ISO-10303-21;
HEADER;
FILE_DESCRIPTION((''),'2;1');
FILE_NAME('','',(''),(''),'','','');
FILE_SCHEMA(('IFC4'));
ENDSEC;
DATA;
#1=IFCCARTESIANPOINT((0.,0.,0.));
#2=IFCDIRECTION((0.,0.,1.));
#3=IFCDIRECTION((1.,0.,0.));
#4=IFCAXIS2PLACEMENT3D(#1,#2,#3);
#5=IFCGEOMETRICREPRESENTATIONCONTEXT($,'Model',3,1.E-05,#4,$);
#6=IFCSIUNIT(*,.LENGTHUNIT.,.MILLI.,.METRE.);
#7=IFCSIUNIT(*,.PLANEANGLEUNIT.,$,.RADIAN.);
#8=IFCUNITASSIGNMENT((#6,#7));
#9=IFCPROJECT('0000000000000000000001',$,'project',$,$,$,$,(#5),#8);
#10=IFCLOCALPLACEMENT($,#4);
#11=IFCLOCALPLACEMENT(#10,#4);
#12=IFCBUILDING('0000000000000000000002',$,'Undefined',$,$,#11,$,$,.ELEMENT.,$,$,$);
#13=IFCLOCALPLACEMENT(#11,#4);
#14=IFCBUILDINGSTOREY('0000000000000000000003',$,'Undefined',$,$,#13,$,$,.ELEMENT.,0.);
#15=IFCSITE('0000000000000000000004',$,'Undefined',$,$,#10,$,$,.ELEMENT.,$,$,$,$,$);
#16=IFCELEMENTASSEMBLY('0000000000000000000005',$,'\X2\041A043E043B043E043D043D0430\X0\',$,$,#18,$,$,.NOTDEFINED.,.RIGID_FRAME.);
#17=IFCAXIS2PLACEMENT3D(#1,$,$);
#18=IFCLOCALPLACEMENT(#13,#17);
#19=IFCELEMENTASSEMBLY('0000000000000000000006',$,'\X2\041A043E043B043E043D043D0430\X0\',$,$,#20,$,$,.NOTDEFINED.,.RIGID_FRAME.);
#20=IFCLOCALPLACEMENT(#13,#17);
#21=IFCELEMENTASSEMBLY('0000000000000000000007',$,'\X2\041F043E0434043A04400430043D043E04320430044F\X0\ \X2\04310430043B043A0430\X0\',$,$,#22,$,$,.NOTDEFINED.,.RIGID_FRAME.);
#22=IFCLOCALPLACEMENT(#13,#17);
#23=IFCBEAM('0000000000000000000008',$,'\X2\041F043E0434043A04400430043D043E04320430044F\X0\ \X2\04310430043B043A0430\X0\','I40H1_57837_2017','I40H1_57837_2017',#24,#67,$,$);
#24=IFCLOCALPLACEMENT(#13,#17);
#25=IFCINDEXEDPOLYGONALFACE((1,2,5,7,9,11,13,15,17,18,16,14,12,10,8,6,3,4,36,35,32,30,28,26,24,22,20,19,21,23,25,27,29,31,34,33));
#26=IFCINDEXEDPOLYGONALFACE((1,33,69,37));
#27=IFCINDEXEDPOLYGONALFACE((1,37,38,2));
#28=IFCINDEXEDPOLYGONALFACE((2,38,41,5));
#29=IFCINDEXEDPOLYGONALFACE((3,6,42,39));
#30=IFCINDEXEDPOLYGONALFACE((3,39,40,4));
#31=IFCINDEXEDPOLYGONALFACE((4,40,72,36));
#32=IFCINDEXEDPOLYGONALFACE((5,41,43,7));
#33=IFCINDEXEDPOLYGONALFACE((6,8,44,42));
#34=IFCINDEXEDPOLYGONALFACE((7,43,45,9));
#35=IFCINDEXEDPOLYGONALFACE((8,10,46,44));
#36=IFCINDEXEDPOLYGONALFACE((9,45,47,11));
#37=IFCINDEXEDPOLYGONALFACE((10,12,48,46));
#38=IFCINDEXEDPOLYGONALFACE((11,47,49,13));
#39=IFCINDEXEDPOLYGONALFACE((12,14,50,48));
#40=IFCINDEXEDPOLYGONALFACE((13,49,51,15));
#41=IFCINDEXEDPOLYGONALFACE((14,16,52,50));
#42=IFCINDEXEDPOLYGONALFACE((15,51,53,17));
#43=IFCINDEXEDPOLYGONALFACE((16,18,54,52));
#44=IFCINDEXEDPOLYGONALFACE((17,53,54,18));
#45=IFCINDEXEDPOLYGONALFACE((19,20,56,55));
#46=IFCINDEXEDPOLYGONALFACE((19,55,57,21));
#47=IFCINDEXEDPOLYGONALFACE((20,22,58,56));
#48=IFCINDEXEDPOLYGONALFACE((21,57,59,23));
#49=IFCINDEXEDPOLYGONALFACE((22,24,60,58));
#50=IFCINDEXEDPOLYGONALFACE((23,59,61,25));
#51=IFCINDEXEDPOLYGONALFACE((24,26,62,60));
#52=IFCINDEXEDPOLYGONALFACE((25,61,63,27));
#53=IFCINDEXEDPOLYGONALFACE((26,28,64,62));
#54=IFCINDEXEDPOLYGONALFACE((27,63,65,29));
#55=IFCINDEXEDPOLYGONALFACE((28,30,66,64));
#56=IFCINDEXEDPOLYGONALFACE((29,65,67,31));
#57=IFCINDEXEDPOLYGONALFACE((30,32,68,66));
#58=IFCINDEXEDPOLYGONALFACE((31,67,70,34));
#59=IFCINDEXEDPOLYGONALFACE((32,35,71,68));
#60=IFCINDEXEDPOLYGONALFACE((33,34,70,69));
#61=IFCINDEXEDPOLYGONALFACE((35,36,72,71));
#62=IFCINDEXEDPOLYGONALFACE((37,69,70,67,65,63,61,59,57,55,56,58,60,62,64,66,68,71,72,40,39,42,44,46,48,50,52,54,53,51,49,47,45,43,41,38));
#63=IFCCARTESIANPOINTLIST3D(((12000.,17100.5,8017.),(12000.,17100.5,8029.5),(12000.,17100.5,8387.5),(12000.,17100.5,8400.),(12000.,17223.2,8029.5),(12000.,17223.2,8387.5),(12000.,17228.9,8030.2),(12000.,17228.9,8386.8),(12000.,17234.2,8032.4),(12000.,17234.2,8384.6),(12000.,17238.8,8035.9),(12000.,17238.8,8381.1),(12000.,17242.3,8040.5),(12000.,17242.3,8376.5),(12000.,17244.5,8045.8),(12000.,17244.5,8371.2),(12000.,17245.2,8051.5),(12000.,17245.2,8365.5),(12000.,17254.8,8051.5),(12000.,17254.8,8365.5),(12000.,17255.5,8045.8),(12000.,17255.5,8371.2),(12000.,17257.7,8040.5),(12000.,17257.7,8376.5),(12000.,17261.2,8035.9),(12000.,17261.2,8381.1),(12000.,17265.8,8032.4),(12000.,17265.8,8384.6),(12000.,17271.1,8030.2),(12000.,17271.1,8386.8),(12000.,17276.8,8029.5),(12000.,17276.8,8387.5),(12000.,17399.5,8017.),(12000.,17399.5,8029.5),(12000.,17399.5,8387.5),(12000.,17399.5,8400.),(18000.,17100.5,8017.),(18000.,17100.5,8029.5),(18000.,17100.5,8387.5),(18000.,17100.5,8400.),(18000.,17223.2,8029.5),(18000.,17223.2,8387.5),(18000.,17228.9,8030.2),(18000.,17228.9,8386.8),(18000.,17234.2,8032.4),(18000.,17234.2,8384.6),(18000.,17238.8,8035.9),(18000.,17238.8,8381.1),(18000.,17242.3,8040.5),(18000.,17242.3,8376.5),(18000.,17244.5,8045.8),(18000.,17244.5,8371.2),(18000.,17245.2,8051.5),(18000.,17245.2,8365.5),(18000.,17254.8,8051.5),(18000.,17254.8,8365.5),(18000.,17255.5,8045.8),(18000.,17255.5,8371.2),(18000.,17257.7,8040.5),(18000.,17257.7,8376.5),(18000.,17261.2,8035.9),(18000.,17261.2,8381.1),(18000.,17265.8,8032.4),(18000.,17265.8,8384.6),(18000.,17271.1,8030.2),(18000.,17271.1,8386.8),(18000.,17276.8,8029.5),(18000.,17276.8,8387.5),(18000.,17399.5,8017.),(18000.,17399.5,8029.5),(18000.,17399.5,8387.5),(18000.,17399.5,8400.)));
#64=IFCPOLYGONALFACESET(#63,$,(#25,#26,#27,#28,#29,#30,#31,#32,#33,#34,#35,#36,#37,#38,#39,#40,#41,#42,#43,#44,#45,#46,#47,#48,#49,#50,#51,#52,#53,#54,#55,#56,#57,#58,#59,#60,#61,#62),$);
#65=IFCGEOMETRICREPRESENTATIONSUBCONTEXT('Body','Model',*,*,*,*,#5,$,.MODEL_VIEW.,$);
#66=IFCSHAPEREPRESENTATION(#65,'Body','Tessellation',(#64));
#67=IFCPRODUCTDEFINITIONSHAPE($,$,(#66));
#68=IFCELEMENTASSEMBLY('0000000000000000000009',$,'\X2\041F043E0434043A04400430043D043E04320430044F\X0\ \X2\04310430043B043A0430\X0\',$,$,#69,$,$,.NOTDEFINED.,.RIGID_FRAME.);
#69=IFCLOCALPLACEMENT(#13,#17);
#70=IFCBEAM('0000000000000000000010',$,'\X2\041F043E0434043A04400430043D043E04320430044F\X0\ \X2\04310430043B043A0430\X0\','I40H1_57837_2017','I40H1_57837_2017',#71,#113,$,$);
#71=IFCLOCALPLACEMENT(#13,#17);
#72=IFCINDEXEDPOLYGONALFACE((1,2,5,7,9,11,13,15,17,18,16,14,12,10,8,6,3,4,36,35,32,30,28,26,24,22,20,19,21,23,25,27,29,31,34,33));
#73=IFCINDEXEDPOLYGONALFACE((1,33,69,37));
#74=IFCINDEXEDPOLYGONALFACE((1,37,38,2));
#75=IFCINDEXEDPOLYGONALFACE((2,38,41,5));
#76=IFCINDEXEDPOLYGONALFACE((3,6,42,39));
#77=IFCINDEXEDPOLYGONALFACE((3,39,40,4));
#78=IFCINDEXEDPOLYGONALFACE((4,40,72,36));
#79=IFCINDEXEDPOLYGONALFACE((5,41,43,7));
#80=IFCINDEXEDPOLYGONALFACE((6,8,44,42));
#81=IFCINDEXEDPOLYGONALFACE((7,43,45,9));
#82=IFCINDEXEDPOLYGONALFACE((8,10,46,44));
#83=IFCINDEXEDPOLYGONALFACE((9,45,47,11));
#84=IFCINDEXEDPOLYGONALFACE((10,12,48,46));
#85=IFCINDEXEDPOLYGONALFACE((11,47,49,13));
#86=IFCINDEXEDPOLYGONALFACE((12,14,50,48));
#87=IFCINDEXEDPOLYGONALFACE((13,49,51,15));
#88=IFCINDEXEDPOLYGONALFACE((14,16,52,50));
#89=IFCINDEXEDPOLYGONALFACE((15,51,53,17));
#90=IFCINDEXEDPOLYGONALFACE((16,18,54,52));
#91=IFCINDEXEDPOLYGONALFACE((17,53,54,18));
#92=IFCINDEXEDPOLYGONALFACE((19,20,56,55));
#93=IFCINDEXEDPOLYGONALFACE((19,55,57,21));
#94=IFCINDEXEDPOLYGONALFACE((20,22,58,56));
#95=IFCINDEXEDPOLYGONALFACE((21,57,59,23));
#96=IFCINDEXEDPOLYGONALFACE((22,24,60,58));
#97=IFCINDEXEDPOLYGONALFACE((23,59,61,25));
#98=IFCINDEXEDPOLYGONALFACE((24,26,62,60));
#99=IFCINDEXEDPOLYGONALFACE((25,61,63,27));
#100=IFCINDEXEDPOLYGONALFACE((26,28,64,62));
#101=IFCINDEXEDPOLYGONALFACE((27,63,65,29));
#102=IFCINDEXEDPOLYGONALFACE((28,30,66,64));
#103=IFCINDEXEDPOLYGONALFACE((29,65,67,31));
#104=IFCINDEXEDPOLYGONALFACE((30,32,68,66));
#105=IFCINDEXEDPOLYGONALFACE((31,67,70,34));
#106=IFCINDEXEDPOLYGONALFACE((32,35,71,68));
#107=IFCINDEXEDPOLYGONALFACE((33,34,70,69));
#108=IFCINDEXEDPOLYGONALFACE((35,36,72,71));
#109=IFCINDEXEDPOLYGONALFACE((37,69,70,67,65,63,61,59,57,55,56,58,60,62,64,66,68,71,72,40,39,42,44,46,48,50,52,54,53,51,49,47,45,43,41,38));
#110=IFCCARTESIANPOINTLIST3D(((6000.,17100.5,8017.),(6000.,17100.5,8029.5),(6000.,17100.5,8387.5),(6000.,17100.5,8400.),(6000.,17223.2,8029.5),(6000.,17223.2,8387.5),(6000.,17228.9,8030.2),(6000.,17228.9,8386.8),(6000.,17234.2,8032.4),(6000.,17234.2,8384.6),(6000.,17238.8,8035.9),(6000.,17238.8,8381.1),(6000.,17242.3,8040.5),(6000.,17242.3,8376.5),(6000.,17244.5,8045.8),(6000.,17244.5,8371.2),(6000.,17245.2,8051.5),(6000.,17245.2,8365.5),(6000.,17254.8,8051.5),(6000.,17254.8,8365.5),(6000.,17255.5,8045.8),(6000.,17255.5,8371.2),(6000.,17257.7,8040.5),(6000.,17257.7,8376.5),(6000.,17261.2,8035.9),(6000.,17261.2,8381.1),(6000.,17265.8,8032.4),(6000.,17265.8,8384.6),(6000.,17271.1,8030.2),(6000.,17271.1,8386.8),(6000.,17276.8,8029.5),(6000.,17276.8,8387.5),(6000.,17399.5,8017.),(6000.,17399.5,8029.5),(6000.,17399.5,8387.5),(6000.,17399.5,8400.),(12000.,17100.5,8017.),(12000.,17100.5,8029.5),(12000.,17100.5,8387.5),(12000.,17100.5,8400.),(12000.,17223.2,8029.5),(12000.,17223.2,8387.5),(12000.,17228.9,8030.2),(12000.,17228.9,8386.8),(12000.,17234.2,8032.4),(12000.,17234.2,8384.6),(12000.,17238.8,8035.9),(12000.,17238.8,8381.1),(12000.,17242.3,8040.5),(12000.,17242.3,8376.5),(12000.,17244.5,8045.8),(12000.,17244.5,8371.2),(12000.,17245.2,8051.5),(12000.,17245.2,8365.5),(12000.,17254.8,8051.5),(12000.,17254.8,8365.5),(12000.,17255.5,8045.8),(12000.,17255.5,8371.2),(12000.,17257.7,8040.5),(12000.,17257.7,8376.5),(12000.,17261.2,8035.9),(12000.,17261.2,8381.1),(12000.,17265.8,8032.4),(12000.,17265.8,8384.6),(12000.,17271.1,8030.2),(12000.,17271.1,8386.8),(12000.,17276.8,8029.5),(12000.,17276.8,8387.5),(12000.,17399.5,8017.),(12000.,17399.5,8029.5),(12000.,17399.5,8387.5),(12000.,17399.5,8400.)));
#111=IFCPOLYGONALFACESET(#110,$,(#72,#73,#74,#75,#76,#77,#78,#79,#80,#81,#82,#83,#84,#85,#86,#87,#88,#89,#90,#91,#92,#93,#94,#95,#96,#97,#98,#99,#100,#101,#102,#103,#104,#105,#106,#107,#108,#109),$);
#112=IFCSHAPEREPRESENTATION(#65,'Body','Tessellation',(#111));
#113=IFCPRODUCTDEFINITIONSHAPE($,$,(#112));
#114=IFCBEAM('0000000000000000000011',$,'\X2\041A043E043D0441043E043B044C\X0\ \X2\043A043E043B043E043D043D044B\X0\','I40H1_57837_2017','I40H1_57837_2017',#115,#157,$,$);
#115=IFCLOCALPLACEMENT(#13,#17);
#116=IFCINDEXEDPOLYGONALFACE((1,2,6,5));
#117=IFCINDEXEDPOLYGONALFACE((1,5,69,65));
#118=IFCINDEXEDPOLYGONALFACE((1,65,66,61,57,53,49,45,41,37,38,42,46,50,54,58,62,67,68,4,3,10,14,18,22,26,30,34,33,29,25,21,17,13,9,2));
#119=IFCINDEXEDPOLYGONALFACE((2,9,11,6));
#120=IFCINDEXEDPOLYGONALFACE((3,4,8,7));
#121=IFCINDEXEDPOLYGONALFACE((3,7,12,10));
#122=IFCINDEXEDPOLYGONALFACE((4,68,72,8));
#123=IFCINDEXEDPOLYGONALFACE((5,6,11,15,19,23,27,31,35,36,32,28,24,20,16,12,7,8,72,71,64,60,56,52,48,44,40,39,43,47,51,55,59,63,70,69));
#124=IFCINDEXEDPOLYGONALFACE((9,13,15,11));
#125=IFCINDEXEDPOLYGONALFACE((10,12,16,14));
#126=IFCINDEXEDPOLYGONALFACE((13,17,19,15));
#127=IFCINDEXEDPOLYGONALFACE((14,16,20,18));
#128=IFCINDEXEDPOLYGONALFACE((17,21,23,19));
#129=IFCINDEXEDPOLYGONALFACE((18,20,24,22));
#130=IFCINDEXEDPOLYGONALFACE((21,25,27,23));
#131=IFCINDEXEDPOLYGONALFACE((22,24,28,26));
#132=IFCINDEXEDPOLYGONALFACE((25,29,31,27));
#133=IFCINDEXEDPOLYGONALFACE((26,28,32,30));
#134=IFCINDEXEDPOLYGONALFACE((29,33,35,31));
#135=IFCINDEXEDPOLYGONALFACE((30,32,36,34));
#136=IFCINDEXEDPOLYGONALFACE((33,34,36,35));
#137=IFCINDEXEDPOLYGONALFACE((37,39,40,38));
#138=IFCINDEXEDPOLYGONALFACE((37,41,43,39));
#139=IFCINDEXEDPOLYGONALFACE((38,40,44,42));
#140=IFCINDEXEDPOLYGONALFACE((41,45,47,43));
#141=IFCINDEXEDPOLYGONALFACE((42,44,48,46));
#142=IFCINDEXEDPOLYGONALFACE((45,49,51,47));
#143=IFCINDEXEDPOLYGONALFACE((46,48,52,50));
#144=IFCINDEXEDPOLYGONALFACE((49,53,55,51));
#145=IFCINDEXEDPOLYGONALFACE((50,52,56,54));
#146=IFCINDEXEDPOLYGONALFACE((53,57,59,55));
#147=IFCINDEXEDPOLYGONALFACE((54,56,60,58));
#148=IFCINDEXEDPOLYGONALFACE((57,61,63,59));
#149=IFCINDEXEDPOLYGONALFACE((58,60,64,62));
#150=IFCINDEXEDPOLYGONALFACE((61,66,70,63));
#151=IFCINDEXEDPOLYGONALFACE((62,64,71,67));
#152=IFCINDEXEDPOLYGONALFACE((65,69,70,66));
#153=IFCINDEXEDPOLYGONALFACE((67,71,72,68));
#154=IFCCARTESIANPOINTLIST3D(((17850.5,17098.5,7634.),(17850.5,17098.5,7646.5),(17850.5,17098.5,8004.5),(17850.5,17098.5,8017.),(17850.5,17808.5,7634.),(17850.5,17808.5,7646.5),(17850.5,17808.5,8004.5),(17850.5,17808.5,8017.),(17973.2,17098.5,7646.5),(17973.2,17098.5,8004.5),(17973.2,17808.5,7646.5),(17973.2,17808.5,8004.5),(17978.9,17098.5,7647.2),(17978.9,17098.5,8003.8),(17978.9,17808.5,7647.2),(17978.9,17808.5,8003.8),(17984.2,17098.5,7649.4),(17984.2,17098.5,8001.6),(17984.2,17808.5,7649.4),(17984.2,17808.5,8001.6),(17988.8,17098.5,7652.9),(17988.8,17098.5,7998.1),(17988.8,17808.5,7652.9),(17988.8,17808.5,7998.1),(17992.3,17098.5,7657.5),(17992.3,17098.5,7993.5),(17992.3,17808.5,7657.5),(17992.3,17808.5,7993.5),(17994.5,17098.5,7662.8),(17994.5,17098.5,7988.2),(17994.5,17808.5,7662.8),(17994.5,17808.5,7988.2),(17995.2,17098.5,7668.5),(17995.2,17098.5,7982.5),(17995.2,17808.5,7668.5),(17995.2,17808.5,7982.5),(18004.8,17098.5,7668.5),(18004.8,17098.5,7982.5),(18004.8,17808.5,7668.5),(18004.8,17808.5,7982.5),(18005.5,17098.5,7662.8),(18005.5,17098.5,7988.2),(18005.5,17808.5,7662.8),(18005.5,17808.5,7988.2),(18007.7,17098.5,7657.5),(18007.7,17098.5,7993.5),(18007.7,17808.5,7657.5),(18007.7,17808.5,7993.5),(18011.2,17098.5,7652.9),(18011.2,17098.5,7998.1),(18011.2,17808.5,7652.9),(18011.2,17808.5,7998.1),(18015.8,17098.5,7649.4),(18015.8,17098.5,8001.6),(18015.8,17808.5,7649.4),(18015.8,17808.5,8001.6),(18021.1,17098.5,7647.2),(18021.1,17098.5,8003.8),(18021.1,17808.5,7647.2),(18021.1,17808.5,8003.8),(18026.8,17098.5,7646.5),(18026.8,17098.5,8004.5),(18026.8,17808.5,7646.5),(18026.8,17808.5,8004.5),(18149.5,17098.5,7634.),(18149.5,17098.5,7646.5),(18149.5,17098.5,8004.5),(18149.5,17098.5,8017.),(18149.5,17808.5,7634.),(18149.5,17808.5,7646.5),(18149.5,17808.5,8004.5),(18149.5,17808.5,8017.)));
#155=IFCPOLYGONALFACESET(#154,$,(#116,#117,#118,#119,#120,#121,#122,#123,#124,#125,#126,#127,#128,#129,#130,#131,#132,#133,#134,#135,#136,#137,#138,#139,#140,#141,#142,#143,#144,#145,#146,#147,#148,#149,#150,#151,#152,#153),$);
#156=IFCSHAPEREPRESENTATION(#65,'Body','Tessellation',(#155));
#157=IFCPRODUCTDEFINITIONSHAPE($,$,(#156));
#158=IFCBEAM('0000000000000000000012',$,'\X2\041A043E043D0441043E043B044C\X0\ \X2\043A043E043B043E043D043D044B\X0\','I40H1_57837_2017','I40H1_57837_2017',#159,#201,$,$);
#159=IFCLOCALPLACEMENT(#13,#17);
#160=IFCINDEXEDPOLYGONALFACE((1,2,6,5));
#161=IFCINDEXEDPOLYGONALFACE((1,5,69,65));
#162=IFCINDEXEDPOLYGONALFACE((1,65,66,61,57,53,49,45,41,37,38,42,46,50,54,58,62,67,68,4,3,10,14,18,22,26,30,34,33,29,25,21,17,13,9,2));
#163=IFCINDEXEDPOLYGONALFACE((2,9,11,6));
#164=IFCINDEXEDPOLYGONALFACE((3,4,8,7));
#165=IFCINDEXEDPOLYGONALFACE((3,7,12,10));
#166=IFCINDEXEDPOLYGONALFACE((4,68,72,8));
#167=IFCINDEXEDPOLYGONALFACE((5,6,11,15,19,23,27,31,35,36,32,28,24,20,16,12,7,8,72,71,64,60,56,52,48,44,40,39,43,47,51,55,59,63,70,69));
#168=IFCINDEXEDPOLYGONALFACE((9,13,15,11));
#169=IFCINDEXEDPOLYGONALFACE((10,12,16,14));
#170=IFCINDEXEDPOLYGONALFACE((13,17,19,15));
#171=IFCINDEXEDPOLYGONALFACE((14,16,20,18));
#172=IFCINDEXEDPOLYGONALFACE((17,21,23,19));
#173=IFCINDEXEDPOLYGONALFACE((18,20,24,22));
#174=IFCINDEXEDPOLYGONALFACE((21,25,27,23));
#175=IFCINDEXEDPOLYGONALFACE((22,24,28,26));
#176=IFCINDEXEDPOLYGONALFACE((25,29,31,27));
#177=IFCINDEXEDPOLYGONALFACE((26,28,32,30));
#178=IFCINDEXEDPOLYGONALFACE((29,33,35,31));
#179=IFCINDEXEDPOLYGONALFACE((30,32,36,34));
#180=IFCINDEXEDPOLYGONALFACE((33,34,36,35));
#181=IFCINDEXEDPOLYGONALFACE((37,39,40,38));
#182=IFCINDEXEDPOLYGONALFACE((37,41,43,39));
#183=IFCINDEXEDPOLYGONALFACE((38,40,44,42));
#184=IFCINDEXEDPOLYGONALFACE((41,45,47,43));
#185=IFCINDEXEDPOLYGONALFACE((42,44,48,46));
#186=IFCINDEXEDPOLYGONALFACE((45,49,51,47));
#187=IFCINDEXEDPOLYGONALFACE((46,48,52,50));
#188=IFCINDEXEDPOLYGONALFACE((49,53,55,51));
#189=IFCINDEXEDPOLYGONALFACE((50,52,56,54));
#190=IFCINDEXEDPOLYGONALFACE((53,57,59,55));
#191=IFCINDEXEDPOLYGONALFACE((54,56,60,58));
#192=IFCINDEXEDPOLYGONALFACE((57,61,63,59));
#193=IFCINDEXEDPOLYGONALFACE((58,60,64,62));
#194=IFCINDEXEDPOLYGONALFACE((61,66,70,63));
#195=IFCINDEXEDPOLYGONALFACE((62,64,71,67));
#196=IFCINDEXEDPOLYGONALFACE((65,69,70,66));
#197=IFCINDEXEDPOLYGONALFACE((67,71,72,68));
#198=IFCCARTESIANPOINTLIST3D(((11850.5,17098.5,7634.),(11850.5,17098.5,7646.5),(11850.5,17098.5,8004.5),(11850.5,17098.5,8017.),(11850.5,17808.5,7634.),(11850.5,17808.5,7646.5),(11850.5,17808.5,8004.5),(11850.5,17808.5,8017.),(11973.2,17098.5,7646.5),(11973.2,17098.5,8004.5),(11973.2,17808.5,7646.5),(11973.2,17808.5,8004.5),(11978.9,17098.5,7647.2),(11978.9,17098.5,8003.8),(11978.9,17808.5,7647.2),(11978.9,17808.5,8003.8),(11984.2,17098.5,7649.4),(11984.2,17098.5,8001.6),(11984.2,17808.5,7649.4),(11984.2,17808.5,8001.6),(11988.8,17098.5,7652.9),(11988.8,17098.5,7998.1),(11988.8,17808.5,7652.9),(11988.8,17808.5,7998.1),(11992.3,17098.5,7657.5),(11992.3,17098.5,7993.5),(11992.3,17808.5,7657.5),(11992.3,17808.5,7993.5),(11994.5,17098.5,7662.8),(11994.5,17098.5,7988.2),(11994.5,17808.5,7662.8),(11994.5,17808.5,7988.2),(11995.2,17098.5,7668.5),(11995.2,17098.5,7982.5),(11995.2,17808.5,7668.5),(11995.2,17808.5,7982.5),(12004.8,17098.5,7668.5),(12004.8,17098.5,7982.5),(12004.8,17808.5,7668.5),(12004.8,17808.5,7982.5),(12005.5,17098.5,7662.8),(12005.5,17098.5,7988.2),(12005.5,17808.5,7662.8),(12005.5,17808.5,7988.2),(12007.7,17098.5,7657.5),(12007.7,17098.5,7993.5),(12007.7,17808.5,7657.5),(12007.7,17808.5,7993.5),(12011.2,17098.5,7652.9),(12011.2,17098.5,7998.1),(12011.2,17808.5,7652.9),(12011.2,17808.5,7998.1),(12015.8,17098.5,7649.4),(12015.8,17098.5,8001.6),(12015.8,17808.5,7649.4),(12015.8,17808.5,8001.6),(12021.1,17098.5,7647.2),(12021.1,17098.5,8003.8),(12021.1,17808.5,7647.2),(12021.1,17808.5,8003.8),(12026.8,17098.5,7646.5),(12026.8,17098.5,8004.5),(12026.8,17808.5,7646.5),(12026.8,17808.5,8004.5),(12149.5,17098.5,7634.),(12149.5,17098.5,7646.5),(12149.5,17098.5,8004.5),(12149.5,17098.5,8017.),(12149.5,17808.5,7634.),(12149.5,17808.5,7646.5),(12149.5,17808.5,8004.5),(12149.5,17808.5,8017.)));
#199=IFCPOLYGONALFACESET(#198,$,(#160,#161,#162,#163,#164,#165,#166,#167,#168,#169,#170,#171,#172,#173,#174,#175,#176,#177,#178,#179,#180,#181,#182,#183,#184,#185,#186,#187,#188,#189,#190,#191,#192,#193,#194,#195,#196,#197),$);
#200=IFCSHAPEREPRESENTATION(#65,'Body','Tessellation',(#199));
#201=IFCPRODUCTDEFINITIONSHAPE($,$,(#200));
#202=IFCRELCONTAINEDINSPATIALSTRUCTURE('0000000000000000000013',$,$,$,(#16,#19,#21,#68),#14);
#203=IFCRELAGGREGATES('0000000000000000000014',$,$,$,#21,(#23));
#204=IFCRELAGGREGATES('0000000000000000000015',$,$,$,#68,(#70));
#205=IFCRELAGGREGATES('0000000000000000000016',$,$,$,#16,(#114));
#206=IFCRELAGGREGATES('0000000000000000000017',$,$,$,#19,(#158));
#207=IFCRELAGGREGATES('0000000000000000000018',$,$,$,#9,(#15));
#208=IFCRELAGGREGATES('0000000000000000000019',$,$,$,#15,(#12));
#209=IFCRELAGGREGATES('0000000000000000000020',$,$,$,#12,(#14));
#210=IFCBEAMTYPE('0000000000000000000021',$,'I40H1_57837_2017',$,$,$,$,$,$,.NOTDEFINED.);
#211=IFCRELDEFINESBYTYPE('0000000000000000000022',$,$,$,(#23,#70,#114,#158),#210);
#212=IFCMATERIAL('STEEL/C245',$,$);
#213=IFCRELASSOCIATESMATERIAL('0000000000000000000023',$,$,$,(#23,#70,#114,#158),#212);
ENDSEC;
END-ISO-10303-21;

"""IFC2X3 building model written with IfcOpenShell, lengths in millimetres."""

from ifc_helpers import new_model, si_unit, frame, origin_with_axes, origin_2d_with_axis, place, context, subcontext, project, spatial, i_section, extrude, material, type_object, element, aggregate, save


model = new_model("IFC2X3")

# Units and contexts
model_context = context("Model", 3, precision=1e-05, world=origin_with_axes())
body_context = subcontext(model_context, "Body", "Model", "MODEL_VIEW")
ifc_project = project(units=[si_unit("LENGTHUNIT", "METRE", prefix="MILLI"), si_unit("PLANEANGLEUNIT", "RADIAN")], contexts=[model_context])

# Site, building, storey
site_placement = place(None, origin_with_axes())
site = spatial("IfcSite", under=ifc_project, at=site_placement, Name="Undefined", CompositionType="ELEMENT")
building_placement = place(site_placement, origin_with_axes())
building = spatial("IfcBuilding", under=site, at=building_placement, Name="Undefined", CompositionType="ELEMENT")
storey_placement = place(building_placement, origin_with_axes())
storey = spatial("IfcBuildingStorey", under=building, at=storey_placement, Name="Undefined", CompositionType="ELEMENT", Elevation=0.0)

# Element assemblies
assembly_1_placement = place(storey_placement, origin_with_axes())
assembly_1 = element("IfcElementAssembly", 1, at=assembly_1_placement, inside=storey, Name="Колонна", AssemblyPlace="NOTDEFINED", PredefinedType="RIGID_FRAME")
ifc_material_1 = material(Name="STEEL/C245")
assembly_2_placement = place(storey_placement, origin_with_axes())
assembly_2 = element("IfcElementAssembly", 2, at=assembly_2_placement, inside=storey, Name="Колонна", AssemblyPlace="NOTDEFINED", PredefinedType="RIGID_FRAME")

# Element assemblies, beams
beam_type_1 = type_object("IfcBeamType", Name="I40H1_57837_2017", PredefinedType="NOTDEFINED")
assembly_3_placement = place(storey_placement, origin_with_axes())
assembly_3 = element("IfcElementAssembly", 3, at=assembly_3_placement, inside=storey, Name="Подкрановая балка", AssemblyPlace="NOTDEFINED", PredefinedType="RIGID_FRAME")
beam_1_placement = place(assembly_3_placement, frame((18000.0, 17250.0, 8208.5), z_axis=(0.0, 0.0, 1.0), x_axis=(-1.0, 0.0, 0.0)))
beam_1 = element("IfcBeam", 4, at=beam_1_placement, type_object=beam_type_1, material=ifc_material_1, Name="Подкрановая балка", Description="I40H1_57837_2017", ObjectType="I40H1_57837_2017", context=body_context, shape_type="SweptSolid", body=[
    extrude(i_section(OverallWidth=299.0, OverallDepth=383.0, WebThickness=9.5, FlangeThickness=12.5, FilletRadius=22.0, at=origin_2d_with_axis()), frame((6000.0, 0.0, 0.0), z_axis=(-1.0, 0.0, 0.0), x_axis=(0.0, -1.0, 0.0)), (0.0, 0.0, 1.0), 6000.0),
])
aggregate(assembly_3, [beam_1])
assembly_4_placement = place(storey_placement, origin_with_axes())
assembly_4 = element("IfcElementAssembly", 5, at=assembly_4_placement, inside=storey, Name="Подкрановая балка", AssemblyPlace="NOTDEFINED", PredefinedType="RIGID_FRAME")
beam_2_placement = place(assembly_4_placement, frame((12000.0, 17250.0, 8208.5), z_axis=(0.0, 0.0, 1.0), x_axis=(-1.0, 0.0, 0.0)))
beam_2 = element("IfcBeam", 6, at=beam_2_placement, type_object=beam_type_1, material=ifc_material_1, Name="Подкрановая балка", Description="I40H1_57837_2017", ObjectType="I40H1_57837_2017", context=body_context, shape_type="SweptSolid", body=[
    extrude(i_section(OverallWidth=299.0, OverallDepth=383.0, WebThickness=9.5, FlangeThickness=12.5, FilletRadius=22.0, at=origin_2d_with_axis()), frame((6000.0, 0.0, 0.0), z_axis=(-1.0, 0.0, 0.0), x_axis=(0.0, -1.0, 0.0)), (0.0, 0.0, 1.0), 6000.0),
])
aggregate(assembly_4, [beam_2])

# Beams
beam_3_placement = place(assembly_1_placement, frame((18000.0, 17098.5, 7825.5), z_axis=(0.0, 0.0, 1.0), x_axis=(0.0, 1.0, 0.0)))
beam_3 = element("IfcBeam", 7, at=beam_3_placement, type_object=beam_type_1, material=ifc_material_1, Name="Консоль колонны", Description="I40H1_57837_2017", ObjectType="I40H1_57837_2017", context=body_context, shape_type="SweptSolid", body=[
    extrude(i_section(OverallWidth=299.0, OverallDepth=383.0, WebThickness=9.5, FlangeThickness=12.5, FilletRadius=22.0, at=origin_2d_with_axis()), frame((710.0, 0.0, 0.0), z_axis=(-1.0, 0.0, 0.0), x_axis=(0.0, -1.0, 0.0)), (0.0, 0.0, 1.0), 710.0),
])
aggregate(assembly_1, [beam_3])
beam_4_placement = place(assembly_2_placement, frame((12000.0, 17098.5, 7825.5), z_axis=(0.0, 0.0, 1.0), x_axis=(0.0, 1.0, 0.0)))
beam_4 = element("IfcBeam", 8, at=beam_4_placement, type_object=beam_type_1, material=ifc_material_1, Name="Консоль колонны", Description="I40H1_57837_2017", ObjectType="I40H1_57837_2017", context=body_context, shape_type="SweptSolid", body=[
    extrude(i_section(OverallWidth=299.0, OverallDepth=383.0, WebThickness=9.5, FlangeThickness=12.5, FilletRadius=22.0, at=origin_2d_with_axis()), frame((710.0, 0.0, 0.0), z_axis=(-1.0, 0.0, 0.0), x_axis=(0.0, -1.0, 0.0)), (0.0, 0.0, 1.0), 710.0),
])
aggregate(assembly_2, [beam_4])

save(model, "model.ifc")
